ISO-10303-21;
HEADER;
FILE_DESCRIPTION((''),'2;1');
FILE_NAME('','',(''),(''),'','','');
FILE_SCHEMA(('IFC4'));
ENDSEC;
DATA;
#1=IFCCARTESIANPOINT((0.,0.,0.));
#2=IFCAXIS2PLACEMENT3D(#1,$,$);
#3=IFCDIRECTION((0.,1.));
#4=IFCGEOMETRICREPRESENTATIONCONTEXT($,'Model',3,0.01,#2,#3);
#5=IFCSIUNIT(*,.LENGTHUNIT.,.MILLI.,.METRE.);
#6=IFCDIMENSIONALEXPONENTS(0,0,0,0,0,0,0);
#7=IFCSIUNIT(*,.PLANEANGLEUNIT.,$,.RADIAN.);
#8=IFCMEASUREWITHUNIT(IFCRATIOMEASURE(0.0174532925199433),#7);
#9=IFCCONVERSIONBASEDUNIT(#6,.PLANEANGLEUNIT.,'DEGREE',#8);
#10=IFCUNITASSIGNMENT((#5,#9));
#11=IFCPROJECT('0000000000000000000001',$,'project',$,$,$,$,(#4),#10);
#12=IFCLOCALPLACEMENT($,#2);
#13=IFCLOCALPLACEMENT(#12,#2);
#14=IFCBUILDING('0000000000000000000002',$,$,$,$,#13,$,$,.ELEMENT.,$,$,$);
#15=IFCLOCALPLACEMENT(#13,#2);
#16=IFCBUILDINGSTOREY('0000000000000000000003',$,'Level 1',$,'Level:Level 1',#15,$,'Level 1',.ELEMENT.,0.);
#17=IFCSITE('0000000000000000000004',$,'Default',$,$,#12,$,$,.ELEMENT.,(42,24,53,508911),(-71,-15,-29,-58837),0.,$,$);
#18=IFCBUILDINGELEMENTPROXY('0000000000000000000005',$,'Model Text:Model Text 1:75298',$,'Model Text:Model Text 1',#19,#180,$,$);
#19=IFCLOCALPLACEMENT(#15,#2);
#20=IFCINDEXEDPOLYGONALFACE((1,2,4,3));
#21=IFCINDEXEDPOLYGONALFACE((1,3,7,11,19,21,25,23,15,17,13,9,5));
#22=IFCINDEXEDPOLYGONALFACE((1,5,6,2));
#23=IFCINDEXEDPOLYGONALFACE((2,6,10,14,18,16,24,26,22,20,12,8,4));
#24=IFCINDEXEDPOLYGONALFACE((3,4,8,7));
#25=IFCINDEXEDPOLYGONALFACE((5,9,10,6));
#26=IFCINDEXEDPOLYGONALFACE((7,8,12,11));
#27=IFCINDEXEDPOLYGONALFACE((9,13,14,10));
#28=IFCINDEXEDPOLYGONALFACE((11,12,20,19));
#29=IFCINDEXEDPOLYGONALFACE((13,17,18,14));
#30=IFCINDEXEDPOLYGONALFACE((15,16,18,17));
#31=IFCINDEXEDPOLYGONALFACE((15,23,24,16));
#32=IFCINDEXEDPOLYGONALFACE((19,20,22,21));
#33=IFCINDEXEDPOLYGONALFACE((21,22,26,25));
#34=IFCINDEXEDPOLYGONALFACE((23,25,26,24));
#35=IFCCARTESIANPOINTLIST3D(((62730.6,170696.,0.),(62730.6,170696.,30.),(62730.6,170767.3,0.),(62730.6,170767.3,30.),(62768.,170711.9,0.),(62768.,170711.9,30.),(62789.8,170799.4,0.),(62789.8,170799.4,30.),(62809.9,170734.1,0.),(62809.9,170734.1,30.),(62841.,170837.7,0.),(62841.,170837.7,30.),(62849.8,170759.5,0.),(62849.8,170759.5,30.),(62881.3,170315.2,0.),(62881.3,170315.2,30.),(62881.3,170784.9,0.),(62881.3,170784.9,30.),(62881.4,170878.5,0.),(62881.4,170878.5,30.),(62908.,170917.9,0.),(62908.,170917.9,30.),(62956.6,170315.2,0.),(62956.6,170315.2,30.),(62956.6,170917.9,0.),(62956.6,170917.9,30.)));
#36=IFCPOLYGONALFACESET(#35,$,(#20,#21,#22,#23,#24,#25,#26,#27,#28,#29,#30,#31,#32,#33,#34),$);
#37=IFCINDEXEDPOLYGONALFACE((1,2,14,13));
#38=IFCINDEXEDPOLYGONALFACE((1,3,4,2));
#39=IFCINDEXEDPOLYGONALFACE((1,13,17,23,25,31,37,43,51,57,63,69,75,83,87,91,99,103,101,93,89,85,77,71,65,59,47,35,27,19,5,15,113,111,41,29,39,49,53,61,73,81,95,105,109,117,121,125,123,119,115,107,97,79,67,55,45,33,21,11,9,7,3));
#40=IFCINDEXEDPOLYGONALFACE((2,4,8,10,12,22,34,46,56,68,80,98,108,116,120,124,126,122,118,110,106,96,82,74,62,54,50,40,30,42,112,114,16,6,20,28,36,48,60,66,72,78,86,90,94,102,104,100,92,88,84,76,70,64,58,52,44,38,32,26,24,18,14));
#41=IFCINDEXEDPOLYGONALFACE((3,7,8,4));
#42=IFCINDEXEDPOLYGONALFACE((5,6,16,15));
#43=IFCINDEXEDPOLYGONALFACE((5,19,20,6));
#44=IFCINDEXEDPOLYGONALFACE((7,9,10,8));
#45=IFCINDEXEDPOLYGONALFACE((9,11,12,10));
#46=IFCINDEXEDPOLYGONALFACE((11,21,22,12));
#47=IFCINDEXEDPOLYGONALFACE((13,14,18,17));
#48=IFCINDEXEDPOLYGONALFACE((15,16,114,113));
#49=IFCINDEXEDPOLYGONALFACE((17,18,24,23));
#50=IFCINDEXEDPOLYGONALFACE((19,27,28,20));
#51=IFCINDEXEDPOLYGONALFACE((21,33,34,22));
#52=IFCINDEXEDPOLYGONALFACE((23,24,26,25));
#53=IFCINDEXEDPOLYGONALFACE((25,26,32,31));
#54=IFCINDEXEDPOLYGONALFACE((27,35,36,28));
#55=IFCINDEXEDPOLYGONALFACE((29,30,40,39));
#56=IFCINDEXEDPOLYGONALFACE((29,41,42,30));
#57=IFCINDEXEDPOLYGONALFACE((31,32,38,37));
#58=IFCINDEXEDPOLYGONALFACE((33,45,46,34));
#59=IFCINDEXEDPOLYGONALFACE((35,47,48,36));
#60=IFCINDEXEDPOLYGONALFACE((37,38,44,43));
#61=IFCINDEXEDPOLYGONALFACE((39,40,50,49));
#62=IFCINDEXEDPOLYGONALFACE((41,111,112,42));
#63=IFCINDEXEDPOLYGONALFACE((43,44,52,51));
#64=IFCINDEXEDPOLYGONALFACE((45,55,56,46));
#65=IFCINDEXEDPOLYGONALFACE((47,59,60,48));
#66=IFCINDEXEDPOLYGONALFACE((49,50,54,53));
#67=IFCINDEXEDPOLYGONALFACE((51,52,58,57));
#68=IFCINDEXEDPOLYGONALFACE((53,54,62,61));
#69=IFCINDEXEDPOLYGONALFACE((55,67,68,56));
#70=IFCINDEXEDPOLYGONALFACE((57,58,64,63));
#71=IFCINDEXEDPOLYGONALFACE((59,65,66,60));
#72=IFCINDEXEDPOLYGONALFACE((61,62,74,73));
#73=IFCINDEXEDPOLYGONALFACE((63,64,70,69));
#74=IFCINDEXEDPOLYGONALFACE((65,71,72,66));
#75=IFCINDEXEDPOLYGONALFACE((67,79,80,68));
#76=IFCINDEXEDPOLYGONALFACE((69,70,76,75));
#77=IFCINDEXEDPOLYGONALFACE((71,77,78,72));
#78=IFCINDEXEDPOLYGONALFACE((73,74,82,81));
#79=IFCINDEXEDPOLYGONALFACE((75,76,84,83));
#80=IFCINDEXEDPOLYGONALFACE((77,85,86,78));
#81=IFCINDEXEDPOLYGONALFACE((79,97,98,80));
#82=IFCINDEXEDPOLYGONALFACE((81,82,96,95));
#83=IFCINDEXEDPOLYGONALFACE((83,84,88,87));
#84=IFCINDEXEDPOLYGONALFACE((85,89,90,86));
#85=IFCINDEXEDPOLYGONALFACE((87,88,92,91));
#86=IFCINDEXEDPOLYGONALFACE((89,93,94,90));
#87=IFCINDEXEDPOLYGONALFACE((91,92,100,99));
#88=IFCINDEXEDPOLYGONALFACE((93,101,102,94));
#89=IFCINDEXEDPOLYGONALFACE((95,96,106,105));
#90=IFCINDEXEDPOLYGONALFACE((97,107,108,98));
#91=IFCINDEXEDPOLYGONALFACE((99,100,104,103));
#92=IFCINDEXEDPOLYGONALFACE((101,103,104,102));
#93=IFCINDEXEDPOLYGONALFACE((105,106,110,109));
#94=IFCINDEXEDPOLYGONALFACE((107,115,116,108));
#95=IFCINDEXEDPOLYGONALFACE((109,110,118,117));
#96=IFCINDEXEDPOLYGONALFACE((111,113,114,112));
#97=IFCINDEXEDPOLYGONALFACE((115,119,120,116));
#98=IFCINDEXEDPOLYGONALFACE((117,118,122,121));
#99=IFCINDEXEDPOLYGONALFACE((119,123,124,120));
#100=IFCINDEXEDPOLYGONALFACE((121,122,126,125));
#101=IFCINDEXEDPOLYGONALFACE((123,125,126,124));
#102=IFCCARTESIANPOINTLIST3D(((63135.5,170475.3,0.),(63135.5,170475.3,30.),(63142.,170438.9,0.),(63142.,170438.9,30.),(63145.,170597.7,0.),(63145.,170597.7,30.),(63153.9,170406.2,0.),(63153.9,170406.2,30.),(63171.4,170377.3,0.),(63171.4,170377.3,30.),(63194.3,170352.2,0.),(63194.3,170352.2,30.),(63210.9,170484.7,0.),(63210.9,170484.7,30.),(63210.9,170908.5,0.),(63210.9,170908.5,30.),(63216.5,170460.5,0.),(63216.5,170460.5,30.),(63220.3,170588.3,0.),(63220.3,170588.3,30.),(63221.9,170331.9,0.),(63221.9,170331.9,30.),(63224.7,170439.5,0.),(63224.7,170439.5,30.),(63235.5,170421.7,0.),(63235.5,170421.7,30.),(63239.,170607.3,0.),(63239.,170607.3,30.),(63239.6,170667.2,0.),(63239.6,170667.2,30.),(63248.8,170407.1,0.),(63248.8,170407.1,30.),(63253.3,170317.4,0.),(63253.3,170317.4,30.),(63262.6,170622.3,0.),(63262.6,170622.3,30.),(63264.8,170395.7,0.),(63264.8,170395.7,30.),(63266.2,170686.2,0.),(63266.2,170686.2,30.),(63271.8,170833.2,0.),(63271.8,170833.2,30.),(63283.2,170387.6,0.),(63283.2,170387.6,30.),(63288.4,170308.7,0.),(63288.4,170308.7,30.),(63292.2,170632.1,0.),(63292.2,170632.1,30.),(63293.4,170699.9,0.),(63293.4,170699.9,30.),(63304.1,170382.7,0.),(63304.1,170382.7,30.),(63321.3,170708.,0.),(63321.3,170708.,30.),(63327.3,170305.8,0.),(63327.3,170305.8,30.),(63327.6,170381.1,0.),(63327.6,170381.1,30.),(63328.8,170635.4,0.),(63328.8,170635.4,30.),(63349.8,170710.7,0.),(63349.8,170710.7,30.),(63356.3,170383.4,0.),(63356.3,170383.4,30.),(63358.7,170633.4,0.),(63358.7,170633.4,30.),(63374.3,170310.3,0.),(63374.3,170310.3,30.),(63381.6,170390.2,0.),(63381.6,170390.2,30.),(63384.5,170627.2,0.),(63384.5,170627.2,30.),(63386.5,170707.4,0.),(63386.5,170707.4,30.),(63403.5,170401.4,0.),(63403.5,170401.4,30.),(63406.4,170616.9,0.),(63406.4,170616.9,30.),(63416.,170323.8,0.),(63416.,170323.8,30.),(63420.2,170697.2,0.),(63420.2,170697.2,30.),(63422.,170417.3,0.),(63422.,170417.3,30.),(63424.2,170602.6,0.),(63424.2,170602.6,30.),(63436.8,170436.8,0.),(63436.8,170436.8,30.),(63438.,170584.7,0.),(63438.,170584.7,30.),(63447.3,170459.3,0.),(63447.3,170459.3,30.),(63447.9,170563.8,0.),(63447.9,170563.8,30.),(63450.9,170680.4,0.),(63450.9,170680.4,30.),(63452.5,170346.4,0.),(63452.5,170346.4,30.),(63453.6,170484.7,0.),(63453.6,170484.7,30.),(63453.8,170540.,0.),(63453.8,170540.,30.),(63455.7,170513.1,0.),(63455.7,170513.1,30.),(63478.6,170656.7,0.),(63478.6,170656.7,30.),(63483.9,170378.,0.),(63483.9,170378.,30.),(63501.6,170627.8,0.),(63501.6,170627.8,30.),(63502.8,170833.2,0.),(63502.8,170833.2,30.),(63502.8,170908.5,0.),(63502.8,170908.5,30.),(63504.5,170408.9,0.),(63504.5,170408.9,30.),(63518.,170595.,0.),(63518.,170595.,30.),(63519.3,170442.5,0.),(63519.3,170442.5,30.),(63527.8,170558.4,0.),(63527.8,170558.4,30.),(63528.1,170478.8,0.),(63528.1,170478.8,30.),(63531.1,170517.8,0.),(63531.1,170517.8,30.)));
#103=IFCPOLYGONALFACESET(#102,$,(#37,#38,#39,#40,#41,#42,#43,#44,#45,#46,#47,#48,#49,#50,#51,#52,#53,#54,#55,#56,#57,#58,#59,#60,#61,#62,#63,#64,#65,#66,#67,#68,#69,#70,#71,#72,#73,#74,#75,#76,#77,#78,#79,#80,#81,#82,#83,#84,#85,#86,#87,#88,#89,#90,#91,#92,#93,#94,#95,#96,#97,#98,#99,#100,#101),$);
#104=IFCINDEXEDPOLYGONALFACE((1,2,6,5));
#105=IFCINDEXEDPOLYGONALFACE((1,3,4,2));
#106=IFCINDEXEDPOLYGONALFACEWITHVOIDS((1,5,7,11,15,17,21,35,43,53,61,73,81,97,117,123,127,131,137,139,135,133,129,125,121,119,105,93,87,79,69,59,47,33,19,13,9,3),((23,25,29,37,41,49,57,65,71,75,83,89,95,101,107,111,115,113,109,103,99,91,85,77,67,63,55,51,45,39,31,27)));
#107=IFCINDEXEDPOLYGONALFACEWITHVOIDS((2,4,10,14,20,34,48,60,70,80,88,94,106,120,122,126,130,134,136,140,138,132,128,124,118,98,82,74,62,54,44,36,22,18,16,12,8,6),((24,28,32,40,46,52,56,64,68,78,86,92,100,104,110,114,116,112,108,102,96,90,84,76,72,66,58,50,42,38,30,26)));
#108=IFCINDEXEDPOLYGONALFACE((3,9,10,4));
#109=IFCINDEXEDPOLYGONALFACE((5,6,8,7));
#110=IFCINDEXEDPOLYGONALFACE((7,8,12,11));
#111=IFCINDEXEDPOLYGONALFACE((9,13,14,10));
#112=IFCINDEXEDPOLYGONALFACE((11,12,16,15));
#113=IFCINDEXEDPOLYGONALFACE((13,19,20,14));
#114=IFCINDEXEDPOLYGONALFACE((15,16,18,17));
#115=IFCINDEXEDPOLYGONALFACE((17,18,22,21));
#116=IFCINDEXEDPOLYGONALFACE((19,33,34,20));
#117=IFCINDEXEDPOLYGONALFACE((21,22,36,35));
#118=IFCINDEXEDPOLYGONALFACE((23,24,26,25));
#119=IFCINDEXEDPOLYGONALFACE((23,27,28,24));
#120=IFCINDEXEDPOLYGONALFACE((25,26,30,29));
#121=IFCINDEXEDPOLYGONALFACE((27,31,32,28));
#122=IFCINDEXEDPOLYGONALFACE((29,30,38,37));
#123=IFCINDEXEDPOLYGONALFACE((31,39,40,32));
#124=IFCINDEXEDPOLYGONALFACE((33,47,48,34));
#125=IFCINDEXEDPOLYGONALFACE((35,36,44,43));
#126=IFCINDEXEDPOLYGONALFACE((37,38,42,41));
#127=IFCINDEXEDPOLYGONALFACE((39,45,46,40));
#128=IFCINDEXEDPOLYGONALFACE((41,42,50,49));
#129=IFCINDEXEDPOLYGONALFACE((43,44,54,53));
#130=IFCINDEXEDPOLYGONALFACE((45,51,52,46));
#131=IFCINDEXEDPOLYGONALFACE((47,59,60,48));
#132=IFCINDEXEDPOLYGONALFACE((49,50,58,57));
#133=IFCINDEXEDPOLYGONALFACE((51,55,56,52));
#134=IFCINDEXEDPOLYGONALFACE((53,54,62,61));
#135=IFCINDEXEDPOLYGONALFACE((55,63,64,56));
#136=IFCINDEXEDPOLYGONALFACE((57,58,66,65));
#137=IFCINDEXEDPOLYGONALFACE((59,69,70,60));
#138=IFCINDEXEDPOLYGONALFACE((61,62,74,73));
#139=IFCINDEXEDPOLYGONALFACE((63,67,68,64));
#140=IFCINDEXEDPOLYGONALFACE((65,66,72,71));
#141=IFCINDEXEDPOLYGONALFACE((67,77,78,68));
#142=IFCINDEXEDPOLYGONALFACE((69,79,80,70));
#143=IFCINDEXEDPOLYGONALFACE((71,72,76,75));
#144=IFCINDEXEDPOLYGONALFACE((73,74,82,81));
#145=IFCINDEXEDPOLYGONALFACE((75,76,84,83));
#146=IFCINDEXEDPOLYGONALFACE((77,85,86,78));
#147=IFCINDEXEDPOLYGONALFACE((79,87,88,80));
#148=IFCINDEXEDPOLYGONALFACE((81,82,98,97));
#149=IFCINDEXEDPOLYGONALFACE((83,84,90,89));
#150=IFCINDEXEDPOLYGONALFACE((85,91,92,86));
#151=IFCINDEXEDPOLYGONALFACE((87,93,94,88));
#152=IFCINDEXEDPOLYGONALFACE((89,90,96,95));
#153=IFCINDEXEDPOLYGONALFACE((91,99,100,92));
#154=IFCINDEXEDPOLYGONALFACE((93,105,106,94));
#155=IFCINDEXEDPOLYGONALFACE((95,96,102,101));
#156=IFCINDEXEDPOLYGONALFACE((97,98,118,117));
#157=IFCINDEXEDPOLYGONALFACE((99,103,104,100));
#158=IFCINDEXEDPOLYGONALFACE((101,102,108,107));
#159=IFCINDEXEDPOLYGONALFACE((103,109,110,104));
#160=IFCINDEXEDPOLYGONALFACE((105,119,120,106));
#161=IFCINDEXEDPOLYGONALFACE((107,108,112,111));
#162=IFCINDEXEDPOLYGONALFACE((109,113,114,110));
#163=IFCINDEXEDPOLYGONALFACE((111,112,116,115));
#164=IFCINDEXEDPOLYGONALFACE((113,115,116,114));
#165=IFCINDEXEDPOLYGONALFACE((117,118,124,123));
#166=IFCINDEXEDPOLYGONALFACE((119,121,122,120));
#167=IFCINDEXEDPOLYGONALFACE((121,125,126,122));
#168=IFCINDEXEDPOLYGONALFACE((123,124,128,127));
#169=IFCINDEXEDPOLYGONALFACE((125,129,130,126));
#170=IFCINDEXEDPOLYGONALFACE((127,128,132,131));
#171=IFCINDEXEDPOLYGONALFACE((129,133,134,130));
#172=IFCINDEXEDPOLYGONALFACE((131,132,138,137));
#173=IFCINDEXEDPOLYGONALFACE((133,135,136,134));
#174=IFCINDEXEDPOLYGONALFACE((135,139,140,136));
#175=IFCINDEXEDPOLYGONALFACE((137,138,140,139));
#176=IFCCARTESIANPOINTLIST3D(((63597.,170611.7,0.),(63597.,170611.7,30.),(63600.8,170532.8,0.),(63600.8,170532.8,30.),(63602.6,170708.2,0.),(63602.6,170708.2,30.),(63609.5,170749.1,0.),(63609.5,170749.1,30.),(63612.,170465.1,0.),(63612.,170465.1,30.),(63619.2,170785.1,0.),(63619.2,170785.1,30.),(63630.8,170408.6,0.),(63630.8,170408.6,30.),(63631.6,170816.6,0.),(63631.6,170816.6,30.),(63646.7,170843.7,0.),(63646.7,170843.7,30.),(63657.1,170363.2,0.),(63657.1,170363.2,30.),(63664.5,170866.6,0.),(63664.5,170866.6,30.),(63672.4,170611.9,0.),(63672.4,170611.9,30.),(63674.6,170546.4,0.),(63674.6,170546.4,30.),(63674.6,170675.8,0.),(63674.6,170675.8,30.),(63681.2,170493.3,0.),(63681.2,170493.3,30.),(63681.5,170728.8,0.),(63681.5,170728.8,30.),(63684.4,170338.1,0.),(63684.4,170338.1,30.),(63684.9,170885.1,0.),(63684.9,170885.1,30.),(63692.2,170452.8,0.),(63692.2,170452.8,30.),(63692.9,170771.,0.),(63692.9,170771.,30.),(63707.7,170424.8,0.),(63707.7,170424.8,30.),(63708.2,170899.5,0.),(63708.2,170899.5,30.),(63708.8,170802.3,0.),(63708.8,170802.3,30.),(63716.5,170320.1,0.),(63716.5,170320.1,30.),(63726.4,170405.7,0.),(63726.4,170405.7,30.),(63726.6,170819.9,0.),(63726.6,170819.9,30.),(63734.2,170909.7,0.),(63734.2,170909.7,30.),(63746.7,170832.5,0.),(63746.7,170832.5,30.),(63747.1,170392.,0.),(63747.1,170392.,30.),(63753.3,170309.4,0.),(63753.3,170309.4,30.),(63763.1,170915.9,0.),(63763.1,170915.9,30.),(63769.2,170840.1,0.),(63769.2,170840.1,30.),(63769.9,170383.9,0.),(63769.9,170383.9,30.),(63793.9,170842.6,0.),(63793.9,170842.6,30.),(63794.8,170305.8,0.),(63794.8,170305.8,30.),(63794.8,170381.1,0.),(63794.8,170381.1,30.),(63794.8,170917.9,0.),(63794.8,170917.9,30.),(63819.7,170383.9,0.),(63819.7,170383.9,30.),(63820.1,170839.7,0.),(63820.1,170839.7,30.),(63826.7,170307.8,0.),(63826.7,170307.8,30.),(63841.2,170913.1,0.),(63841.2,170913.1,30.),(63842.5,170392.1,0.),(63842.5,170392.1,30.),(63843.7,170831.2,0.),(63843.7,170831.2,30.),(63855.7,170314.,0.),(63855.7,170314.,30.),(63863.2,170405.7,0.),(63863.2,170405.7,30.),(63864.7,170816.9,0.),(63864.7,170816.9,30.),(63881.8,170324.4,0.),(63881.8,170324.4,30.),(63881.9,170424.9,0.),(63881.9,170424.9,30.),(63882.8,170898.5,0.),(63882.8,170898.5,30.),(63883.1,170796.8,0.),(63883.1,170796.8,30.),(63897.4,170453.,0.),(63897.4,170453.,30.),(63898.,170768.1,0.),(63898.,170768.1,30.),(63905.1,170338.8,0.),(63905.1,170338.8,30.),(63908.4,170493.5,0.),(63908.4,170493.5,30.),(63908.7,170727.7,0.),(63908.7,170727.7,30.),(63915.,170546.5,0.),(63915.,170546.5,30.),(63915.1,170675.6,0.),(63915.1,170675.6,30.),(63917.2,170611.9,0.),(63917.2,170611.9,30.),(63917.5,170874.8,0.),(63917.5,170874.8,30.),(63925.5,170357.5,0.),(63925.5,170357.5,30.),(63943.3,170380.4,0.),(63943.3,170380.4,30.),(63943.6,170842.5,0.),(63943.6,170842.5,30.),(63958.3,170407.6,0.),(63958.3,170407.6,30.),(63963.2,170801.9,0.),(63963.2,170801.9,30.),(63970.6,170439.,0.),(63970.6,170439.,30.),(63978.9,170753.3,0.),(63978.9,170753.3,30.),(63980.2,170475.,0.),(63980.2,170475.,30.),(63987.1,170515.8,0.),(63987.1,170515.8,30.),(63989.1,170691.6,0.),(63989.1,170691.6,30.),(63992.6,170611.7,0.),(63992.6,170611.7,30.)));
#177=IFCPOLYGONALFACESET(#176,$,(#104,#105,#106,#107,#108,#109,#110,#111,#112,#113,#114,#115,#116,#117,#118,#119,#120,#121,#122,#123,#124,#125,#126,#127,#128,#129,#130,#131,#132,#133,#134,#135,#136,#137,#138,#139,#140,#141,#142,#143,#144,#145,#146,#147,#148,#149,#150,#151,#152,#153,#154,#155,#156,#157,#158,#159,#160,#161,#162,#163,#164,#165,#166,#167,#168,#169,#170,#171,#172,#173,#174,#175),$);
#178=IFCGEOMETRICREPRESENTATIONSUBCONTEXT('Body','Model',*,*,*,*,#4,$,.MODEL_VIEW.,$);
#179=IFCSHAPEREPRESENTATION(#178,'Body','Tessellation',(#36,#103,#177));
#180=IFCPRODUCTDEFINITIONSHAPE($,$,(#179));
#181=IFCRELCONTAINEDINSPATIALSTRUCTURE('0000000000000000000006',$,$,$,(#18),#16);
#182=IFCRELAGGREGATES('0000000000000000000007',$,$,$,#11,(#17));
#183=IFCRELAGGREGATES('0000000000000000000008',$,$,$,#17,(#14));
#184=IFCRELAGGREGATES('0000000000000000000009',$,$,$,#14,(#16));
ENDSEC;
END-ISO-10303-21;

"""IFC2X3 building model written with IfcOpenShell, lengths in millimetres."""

from ifc_helpers import new_model, entity, si_unit, converted_unit, direction, frame, origin, place, context, subcontext, project, spatial, polyline, outline, extrude, element, save


model = new_model("IFC2X3")

# Units and contexts
model_context = context("Model", 3, precision=0.01, world=origin(), true_north=direction((0.0, 1.0)))
body_context = subcontext(model_context, "Body", "Model", "MODEL_VIEW")
ifc_project = project(units=[si_unit("LENGTHUNIT", "METRE", prefix="MILLI"), converted_unit("PLANEANGLEUNIT", "DEGREE", entity("IfcRatioMeasure", 0.0174532925199433), si_unit("PLANEANGLEUNIT", "RADIAN"), dimensions=[0, 0, 0, 0, 0, 0, 0])], contexts=[model_context])

# Site, building, storey
site_placement = place(None, origin())
site = spatial("IfcSite", under=ifc_project, at=site_placement, Name="Default", CompositionType="ELEMENT", RefLatitude=(42, 24, 53, 508911), RefLongitude=(-71, -15, -29, -58837), RefElevation=0.0)
building_placement = place(site_placement, origin())
building = spatial("IfcBuilding", under=site, at=building_placement, CompositionType="ELEMENT")
storey_placement = place(building_placement, origin())
storey = spatial("IfcBuildingStorey", under=building, at=storey_placement, Name="Level 1", ObjectType="Level:Level 1", LongName="Level 1", CompositionType="ELEMENT", Elevation=0.0)

# Building element proxy
proxy_1_placement = place(storey_placement, origin())
element("IfcBuildingElementProxy", 1, at=proxy_1_placement, inside=storey, Name="Model Text:Model Text 1:75298", ObjectType="Model Text:Model Text 1", context=body_context, shape_type="SweptSolid", body=[
    extrude(outline(polyline([(-410.6, -111.6), (192.1, -111.6), (192.1, -63.1), (152.7, -36.4), (111.9, 4.0), (73.6, 55.2), (41.4, 114.4), (-29.8, 114.4), (-13.9, 77.0), (8.3, 35.1), (33.7, -4.8), (59.1, -36.3), (-410.6, -36.3), (-410.6, -111.6)])), frame((62845.0, 170725.8, 0.0), z_axis=(0.0, 0.0, 1.0), x_axis=(0.0, 1.0, 0.0)), (0.0, 0.0, 1.0), 30.0),
    extrude(outline(polyline([(12.1, -219.3), (49.1, -219.3), (83.4, -213.2), (114.8, -201.1), (143.5, -182.8), (168.3, -159.2), (188.1, -130.8), (202.8, -97.8), (212.4, -60.0), (216.1, -12.9), (210.0, 30.5), (194.1, 70.4), (168.4, 106.8), (141.6, 132.5), (111.1, 152.9), (76.9, 167.9), (39.0, 177.6), (-1.5, 181.4), (-39.3, 178.1), (-74.4, 167.6), (-106.9, 150.1), (-135.0, 126.9), (-157.0, 99.6), (-172.8, 68.1), (-182.5, 32.6), (-184.8, 4.0), (-181.6, -24.8), (-172.9, -54.0), (-158.8, -83.5), (-316.6, -22.9), (-276.5, 204.6), (-350.7, 217.7), (-401.4, -69.8), (-106.8, -188.8), (-84.5, -116.2), (-99.9, -94.5), (-110.6, -68.6), (-115.1, -37.8), (-112.0, -1.2), (-104.8, 27.9), (-94.2, 52.3), (-80.3, 72.0), (-63.1, 87.0), (-43.0, 97.5), (-20.8, 103.6), (3.8, 105.3), (30.5, 102.6), (58.1, 95.6), (82.1, 84.9), (102.4, 70.6), (119.1, 52.7), (131.4, 31.7), (138.7, 8.2), (141.0, -17.9), (138.2, -46.6), (132.6, -69.4), (124.1, -89.2), (112.9, -105.9), (99.0, -119.6), (82.3, -130.2), (62.9, -137.7), (40.8, -142.2), (15.9, -143.5), (12.1, -219.3)])), frame((63349.4, 170525.4, 0.0), z_axis=(0.0, 0.0, 1.0), x_axis=(0.173842, -0.984774, 0.0)), (0.0, 0.0, 1.0), 30.0),
    extrude(outline(polyline([(-10.6, -198.7), (68.3, -198.7), (136.5, -190.7), (193.9, -174.7), (240.5, -150.6), (266.9, -124.4), (286.3, -93.2), (298.8, -57.0), (304.3, -15.7), (303.8, 16.2), (299.0, 45.5), (289.9, 72.1), (276.6, 96.0), (258.9, 117.3), (236.9, 136.2), (210.4, 152.5), (179.6, 166.3), (144.1, 177.6), (103.7, 186.3), (8.2, 196.4), (-71.8, 196.7), (-134.0, 189.4), (-183.3, 176.1), (-224.7, 158.4), (-258.2, 133.9), (-283.5, 100.3), (-300.1, 59.5), (-307.1, 13.4), (-306.6, -18.4), (-301.8, -47.5), (-292.8, -74.0), (-279.6, -97.9), (-262.0, -119.2), (-240.0, -138.1), (-213.6, -154.5), (-182.8, -168.4), (-147.3, -179.8), (-106.7, -188.6), (-10.6, -198.7)]), holes=[polyline([(-7.2, -123.5), (-71.0, -118.2), (-123.6, -108.8), (-165.2, -95.4), (-195.7, -78.0), (-212.4, -59.4), (-224.1, -38.7), (-230.6, -15.9), (-231.9, 8.9), (-227.8, 35.0), (-218.1, 58.1), (-202.8, 78.4), (-182.0, 95.8), (-152.6, 109.4), (-111.7, 118.1), (-59.4, 122.0), (4.4, 121.1), (69.6, 115.8), (122.2, 106.7), (162.2, 93.7), (189.5, 77.0), (207.7, 57.4), (220.4, 36.0), (227.5, 12.8), (229.1, -12.1), (225.2, -36.8), (215.9, -59.2), (201.3, -79.3), (181.4, -97.1), (152.6, -111.2), (111.6, -120.3), (58.3, -124.4), (-7.2, -123.5)])]), frame((63796.0, 170610.5, 0.0), z_axis=(0.0, 0.0, 1.0), x_axis=(0.047515, -0.998871, 0.0)), (0.0, 0.0, 1.0), 30.0),
])

save(model, "model.ifc")
